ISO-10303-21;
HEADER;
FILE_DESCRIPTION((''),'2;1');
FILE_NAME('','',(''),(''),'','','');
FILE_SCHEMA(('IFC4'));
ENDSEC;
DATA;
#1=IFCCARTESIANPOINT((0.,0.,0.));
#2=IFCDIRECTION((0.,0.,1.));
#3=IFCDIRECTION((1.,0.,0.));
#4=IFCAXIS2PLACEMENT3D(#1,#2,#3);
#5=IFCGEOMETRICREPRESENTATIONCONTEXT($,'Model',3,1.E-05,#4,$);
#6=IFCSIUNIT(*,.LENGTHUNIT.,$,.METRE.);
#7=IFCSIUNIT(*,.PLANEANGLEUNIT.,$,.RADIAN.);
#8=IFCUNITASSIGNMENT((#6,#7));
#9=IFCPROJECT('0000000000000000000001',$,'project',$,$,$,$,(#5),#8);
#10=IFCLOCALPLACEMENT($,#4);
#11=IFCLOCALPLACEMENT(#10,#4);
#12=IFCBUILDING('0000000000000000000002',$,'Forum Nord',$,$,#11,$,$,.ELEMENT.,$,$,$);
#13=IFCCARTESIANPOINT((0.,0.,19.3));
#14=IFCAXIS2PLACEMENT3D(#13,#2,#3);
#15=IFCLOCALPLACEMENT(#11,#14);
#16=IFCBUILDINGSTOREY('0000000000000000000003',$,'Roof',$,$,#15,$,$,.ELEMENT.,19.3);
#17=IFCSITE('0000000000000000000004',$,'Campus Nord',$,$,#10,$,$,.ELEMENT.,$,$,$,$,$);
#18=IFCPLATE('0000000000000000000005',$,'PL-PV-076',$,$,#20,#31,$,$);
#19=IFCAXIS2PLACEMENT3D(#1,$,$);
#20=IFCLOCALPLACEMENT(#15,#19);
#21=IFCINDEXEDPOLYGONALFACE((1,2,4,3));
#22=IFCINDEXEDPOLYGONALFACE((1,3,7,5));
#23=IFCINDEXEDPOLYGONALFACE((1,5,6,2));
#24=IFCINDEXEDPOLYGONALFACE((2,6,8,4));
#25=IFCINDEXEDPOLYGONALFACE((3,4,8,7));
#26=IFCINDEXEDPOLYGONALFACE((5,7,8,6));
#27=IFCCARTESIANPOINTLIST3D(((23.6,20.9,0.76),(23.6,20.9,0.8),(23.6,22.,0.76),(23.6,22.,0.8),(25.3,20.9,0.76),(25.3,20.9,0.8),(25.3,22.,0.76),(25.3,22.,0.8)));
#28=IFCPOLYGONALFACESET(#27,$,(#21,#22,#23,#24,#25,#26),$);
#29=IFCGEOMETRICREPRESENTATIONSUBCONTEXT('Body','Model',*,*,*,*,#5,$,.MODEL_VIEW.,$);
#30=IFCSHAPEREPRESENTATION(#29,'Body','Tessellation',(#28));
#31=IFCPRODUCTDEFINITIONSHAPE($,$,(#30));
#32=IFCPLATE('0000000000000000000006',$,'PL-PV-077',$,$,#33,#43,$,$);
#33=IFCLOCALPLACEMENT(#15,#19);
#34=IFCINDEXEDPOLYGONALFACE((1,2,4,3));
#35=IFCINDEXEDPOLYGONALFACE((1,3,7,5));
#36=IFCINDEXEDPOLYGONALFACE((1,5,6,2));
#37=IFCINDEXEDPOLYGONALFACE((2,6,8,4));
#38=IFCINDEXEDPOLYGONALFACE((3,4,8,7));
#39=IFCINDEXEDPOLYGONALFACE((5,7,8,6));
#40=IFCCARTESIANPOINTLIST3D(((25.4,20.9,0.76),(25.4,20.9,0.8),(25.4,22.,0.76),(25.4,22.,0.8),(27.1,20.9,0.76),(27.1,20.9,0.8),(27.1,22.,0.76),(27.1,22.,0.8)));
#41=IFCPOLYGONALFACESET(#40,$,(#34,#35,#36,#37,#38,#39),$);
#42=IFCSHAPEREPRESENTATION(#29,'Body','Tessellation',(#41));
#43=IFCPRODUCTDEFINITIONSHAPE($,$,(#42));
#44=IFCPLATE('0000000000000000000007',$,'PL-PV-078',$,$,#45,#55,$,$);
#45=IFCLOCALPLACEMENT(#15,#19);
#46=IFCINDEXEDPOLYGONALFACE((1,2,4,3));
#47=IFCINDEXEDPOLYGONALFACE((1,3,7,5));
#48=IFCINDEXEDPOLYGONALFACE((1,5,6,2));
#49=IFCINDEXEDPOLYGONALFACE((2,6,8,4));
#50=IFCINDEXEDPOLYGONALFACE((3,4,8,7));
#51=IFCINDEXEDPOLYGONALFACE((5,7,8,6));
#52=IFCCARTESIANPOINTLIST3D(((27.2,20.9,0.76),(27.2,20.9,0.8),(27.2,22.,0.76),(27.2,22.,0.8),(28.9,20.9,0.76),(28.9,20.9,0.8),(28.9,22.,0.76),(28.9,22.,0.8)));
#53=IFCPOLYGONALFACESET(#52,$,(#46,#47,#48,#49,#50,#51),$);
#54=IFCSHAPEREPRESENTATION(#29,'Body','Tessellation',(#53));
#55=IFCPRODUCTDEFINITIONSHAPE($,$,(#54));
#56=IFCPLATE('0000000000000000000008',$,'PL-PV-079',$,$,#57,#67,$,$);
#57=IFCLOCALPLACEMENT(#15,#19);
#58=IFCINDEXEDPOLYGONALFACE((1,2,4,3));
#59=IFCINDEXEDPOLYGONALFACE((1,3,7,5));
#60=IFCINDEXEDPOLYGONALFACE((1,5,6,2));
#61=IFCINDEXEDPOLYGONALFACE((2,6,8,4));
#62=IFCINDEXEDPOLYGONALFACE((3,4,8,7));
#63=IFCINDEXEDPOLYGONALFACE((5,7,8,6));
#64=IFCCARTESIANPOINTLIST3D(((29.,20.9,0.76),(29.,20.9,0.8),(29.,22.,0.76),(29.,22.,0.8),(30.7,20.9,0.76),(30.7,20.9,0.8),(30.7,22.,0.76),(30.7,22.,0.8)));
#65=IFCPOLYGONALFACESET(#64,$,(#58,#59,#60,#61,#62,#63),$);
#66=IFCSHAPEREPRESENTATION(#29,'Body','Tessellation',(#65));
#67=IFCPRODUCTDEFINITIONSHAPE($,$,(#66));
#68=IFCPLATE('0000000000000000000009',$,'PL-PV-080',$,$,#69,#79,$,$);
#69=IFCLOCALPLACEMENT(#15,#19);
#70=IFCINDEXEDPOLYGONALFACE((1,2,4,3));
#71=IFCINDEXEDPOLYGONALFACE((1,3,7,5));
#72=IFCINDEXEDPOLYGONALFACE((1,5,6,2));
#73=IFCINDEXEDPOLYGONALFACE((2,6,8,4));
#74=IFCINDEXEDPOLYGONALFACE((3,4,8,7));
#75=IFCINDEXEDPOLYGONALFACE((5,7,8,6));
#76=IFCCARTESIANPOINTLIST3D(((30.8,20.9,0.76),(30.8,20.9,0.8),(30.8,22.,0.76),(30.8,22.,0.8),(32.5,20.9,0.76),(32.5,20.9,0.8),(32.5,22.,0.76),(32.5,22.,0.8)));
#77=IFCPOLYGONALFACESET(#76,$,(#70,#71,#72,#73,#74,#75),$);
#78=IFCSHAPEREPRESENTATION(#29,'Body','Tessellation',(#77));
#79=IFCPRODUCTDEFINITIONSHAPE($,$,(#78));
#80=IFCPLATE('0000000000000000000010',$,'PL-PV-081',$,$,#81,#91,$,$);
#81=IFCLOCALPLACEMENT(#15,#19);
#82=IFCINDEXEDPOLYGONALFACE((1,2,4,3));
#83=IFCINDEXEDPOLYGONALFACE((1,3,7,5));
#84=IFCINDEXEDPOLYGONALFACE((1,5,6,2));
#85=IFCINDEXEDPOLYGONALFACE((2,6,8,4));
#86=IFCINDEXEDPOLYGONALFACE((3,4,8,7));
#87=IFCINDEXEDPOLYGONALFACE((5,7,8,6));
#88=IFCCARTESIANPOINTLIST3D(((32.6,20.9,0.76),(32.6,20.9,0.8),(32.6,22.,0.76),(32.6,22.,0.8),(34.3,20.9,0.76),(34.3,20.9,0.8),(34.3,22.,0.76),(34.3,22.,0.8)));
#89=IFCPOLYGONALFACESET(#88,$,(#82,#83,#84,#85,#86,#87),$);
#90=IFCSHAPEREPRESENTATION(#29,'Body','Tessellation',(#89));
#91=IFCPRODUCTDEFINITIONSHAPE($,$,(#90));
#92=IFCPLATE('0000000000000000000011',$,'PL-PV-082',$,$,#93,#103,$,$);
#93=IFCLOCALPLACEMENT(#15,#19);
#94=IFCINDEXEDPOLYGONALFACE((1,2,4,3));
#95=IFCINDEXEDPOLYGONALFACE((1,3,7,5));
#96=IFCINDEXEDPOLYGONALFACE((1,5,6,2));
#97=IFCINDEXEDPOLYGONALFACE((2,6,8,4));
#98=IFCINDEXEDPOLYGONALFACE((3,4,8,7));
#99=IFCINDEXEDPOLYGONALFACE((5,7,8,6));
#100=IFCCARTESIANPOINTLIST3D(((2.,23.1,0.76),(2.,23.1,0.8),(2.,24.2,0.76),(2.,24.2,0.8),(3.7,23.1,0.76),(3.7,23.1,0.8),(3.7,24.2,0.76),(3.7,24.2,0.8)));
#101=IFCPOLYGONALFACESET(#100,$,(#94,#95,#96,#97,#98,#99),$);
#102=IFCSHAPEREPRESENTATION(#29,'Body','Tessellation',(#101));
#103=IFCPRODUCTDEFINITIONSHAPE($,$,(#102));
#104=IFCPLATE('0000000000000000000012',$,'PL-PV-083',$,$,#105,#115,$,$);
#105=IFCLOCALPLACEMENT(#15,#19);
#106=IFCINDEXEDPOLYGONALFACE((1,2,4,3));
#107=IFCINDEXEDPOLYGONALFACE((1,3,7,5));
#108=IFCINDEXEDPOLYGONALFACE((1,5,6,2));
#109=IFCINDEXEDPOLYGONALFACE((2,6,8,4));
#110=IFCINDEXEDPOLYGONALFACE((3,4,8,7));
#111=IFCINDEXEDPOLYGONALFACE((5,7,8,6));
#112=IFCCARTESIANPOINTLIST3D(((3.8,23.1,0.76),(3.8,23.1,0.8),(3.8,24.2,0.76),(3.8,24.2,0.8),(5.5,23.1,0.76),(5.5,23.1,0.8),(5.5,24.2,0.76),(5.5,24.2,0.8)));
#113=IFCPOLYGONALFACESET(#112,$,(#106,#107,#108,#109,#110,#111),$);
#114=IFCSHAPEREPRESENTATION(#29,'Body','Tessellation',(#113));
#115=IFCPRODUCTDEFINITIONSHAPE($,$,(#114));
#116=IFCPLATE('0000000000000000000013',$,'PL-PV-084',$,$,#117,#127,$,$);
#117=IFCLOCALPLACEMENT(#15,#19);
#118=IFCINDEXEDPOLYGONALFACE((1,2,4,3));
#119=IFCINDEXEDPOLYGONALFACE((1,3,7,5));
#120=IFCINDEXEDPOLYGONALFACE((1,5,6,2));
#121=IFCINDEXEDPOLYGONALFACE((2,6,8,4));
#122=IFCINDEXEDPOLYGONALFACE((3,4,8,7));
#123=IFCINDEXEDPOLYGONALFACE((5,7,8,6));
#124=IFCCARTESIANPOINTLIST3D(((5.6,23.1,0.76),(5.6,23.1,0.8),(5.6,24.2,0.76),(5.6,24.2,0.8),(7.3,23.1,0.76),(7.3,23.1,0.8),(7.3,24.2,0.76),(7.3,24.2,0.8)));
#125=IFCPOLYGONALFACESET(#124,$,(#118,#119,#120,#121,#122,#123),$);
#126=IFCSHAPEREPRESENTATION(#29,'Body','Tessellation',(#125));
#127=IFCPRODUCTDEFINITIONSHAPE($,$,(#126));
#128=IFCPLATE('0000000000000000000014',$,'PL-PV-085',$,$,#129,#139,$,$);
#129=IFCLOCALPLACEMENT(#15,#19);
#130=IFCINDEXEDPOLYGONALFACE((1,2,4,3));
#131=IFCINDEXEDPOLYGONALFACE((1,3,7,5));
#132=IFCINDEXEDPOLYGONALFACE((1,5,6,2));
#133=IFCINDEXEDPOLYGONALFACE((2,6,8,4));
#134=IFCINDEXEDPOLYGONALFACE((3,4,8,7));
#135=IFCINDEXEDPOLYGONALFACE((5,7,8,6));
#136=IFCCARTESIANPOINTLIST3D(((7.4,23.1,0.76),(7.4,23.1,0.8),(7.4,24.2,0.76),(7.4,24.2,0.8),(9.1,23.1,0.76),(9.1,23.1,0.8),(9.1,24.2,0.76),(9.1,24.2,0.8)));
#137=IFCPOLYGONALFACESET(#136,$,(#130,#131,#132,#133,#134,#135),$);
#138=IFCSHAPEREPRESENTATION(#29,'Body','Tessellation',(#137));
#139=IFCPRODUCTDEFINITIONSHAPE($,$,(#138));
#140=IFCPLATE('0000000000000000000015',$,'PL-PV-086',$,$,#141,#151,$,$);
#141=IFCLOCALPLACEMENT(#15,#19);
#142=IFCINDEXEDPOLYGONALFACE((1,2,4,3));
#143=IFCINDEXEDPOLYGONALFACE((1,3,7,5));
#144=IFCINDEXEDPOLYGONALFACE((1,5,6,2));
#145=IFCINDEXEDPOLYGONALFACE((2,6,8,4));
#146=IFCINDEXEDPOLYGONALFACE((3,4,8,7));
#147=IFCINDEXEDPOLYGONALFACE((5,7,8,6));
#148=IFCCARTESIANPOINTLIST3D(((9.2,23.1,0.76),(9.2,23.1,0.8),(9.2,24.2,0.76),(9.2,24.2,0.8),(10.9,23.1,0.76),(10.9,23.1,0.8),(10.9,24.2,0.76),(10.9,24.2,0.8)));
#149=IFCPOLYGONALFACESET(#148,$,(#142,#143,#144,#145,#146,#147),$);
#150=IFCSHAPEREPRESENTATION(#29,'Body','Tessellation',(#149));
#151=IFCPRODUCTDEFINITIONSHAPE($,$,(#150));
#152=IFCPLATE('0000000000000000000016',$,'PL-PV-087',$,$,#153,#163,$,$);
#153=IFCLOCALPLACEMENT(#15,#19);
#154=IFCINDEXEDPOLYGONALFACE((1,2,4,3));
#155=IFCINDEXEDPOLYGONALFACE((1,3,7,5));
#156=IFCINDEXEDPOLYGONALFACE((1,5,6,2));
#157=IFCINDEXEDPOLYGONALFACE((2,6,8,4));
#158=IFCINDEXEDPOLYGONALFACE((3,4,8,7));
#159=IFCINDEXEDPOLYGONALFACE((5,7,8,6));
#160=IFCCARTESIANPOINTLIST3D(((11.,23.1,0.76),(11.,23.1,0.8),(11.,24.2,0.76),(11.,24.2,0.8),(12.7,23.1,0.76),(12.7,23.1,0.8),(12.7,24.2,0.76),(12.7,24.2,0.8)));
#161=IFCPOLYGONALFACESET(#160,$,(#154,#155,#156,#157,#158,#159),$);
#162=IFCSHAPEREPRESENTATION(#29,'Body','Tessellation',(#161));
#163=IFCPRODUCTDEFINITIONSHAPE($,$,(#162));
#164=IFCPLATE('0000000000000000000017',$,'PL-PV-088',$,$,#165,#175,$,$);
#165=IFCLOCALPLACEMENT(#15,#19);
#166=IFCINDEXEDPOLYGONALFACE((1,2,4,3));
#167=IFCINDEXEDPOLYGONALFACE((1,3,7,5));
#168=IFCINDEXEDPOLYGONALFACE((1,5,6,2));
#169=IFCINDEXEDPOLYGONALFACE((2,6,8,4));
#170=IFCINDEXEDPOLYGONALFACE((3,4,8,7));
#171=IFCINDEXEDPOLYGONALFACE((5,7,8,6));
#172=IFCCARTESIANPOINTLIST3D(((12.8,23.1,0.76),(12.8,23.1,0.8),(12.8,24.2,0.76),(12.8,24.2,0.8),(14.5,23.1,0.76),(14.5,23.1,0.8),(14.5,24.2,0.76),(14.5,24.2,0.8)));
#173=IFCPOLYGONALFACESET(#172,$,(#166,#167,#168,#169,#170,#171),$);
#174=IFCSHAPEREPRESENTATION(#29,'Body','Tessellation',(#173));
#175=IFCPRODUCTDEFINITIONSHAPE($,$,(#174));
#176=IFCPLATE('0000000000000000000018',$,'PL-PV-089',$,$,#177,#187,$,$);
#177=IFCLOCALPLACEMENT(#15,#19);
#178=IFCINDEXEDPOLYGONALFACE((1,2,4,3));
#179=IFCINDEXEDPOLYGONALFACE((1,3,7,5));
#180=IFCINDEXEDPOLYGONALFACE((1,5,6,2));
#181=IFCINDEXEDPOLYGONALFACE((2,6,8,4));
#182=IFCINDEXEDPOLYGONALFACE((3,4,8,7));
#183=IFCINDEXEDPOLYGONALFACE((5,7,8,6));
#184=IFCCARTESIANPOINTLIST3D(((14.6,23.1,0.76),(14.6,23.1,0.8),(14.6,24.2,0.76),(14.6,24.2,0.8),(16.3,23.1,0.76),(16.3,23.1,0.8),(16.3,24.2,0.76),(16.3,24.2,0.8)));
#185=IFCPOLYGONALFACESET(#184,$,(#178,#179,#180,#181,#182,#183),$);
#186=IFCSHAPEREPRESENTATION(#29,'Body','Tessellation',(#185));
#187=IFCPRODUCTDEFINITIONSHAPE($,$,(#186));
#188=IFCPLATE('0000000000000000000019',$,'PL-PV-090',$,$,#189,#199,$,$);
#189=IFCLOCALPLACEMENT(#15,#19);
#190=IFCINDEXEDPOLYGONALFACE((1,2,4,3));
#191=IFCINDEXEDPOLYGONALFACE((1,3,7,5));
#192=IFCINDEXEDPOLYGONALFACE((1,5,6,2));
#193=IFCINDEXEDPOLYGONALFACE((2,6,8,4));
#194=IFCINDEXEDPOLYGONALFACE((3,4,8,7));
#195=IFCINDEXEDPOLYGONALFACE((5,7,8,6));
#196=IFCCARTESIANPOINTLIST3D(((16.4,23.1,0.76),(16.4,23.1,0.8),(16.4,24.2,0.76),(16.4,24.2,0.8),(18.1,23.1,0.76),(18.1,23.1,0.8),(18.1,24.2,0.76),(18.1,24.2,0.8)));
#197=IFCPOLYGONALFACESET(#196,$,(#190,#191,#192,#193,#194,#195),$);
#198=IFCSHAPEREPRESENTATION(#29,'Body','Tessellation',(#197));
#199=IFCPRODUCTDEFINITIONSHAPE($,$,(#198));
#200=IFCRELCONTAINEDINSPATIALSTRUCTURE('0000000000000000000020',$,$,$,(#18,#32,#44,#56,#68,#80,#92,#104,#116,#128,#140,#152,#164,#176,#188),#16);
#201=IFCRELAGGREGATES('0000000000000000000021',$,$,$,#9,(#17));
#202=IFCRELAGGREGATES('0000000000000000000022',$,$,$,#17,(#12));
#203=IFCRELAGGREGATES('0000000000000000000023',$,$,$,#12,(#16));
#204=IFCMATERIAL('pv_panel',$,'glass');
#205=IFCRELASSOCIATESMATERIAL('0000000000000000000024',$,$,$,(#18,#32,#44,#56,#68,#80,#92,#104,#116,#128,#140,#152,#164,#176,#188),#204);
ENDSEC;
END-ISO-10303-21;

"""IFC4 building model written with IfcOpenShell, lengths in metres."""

from ifc_helpers import new_model, si_unit, frame, origin_with_axes, place, context, subcontext, project, spatial, polyline, outline, extrude, material, element, save


model = new_model("IFC4")

# Units and contexts
model_context = context("Model", 3, precision=1e-05, world=origin_with_axes())
body_context = subcontext(model_context, "Body", "Model", "MODEL_VIEW")
ifc_project = project(units=[si_unit("LENGTHUNIT", "METRE"), si_unit("PLANEANGLEUNIT", "RADIAN")], contexts=[model_context])

# Site, building, storey
site_placement = place(None, origin_with_axes())
site = spatial("IfcSite", under=ifc_project, at=site_placement, Name="Campus Nord", CompositionType="ELEMENT")
building_placement = place(site_placement, origin_with_axes())
building = spatial("IfcBuilding", under=site, at=building_placement, Name="Forum Nord", CompositionType="ELEMENT")
storey_placement = place(building_placement, frame((0.0, 0.0, 19.3), z_axis=(0.0, 0.0, 1.0), x_axis=(1.0, 0.0, 0.0)))
storey = spatial("IfcBuildingStorey", under=building, at=storey_placement, Name="Roof", CompositionType="ELEMENT", Elevation=19.3)

# Plates
ifc_material_1 = material(Name="pv_panel", Category="glass")
plate_1_placement = place(storey_placement, frame((0.0, 0.0, 0.8), z_axis=(0.0, 0.0, 1.0), x_axis=(1.0, 0.0, 0.0)))
element("IfcPlate", 1, at=plate_1_placement, inside=storey, material=ifc_material_1, Name="PL-PV-076", context=body_context, shape_type="SweptSolid", body=[
    extrude(outline(polyline([(23.6, 20.9), (25.3, 20.9), (25.3, 22.0), (23.6, 22.0), (23.6, 20.9)])), frame((0.0, 0.0, -0.04), z_axis=(0.0, 0.0, 1.0), x_axis=(1.0, 0.0, 0.0)), (0.0, 0.0, 1.0), 0.04),
])
plate_2_placement = place(storey_placement, frame((0.0, 0.0, 0.8), z_axis=(0.0, 0.0, 1.0), x_axis=(1.0, 0.0, 0.0)))
element("IfcPlate", 2, at=plate_2_placement, inside=storey, material=ifc_material_1, Name="PL-PV-077", context=body_context, shape_type="SweptSolid", body=[
    extrude(outline(polyline([(25.4, 20.9), (27.1, 20.9), (27.1, 22.0), (25.4, 22.0), (25.4, 20.9)])), frame((0.0, 0.0, -0.04), z_axis=(0.0, 0.0, 1.0), x_axis=(1.0, 0.0, 0.0)), (0.0, 0.0, 1.0), 0.04),
])
plate_3_placement = place(storey_placement, frame((0.0, 0.0, 0.8), z_axis=(0.0, 0.0, 1.0), x_axis=(1.0, 0.0, 0.0)))
element("IfcPlate", 3, at=plate_3_placement, inside=storey, material=ifc_material_1, Name="PL-PV-078", context=body_context, shape_type="SweptSolid", body=[
    extrude(outline(polyline([(27.2, 20.9), (28.9, 20.9), (28.9, 22.0), (27.2, 22.0), (27.2, 20.9)])), frame((0.0, 0.0, -0.04), z_axis=(0.0, 0.0, 1.0), x_axis=(1.0, 0.0, 0.0)), (0.0, 0.0, 1.0), 0.04),
])
plate_4_placement = place(storey_placement, frame((0.0, 0.0, 0.8), z_axis=(0.0, 0.0, 1.0), x_axis=(1.0, 0.0, 0.0)))
element("IfcPlate", 4, at=plate_4_placement, inside=storey, material=ifc_material_1, Name="PL-PV-079", context=body_context, shape_type="SweptSolid", body=[
    extrude(outline(polyline([(29.0, 20.9), (30.7, 20.9), (30.7, 22.0), (29.0, 22.0), (29.0, 20.9)])), frame((0.0, 0.0, -0.04), z_axis=(0.0, 0.0, 1.0), x_axis=(1.0, 0.0, 0.0)), (0.0, 0.0, 1.0), 0.04),
])
plate_5_placement = place(storey_placement, frame((0.0, 0.0, 0.8), z_axis=(0.0, 0.0, 1.0), x_axis=(1.0, 0.0, 0.0)))
element("IfcPlate", 5, at=plate_5_placement, inside=storey, material=ifc_material_1, Name="PL-PV-080", context=body_context, shape_type="SweptSolid", body=[
    extrude(outline(polyline([(30.8, 20.9), (32.5, 20.9), (32.5, 22.0), (30.8, 22.0), (30.8, 20.9)])), frame((0.0, 0.0, -0.04), z_axis=(0.0, 0.0, 1.0), x_axis=(1.0, 0.0, 0.0)), (0.0, 0.0, 1.0), 0.04),
])
plate_6_placement = place(storey_placement, frame((0.0, 0.0, 0.8), z_axis=(0.0, 0.0, 1.0), x_axis=(1.0, 0.0, 0.0)))
element("IfcPlate", 6, at=plate_6_placement, inside=storey, material=ifc_material_1, Name="PL-PV-081", context=body_context, shape_type="SweptSolid", body=[
    extrude(outline(polyline([(32.6, 20.9), (34.3, 20.9), (34.3, 22.0), (32.6, 22.0), (32.6, 20.9)])), frame((0.0, 0.0, -0.04), z_axis=(0.0, 0.0, 1.0), x_axis=(1.0, 0.0, 0.0)), (0.0, 0.0, 1.0), 0.04),
])
plate_7_placement = place(storey_placement, frame((0.0, 0.0, 0.8), z_axis=(0.0, 0.0, 1.0), x_axis=(1.0, 0.0, 0.0)))
element("IfcPlate", 7, at=plate_7_placement, inside=storey, material=ifc_material_1, Name="PL-PV-082", context=body_context, shape_type="SweptSolid", body=[
    extrude(outline(polyline([(2.0, 23.1), (3.7, 23.1), (3.7, 24.2), (2.0, 24.2), (2.0, 23.1)])), frame((0.0, 0.0, -0.04), z_axis=(0.0, 0.0, 1.0), x_axis=(1.0, 0.0, 0.0)), (0.0, 0.0, 1.0), 0.04),
])
plate_8_placement = place(storey_placement, frame((0.0, 0.0, 0.8), z_axis=(0.0, 0.0, 1.0), x_axis=(1.0, 0.0, 0.0)))
element("IfcPlate", 8, at=plate_8_placement, inside=storey, material=ifc_material_1, Name="PL-PV-083", context=body_context, shape_type="SweptSolid", body=[
    extrude(outline(polyline([(3.8, 23.1), (5.5, 23.1), (5.5, 24.2), (3.8, 24.2), (3.8, 23.1)])), frame((0.0, 0.0, -0.04), z_axis=(0.0, 0.0, 1.0), x_axis=(1.0, 0.0, 0.0)), (0.0, 0.0, 1.0), 0.04),
])
plate_9_placement = place(storey_placement, frame((0.0, 0.0, 0.8), z_axis=(0.0, 0.0, 1.0), x_axis=(1.0, 0.0, 0.0)))
element("IfcPlate", 9, at=plate_9_placement, inside=storey, material=ifc_material_1, Name="PL-PV-084", context=body_context, shape_type="SweptSolid", body=[
    extrude(outline(polyline([(5.6, 23.1), (7.3, 23.1), (7.3, 24.2), (5.6, 24.2), (5.6, 23.1)])), frame((0.0, 0.0, -0.04), z_axis=(0.0, 0.0, 1.0), x_axis=(1.0, 0.0, 0.0)), (0.0, 0.0, 1.0), 0.04),
])
plate_10_placement = place(storey_placement, frame((0.0, 0.0, 0.8), z_axis=(0.0, 0.0, 1.0), x_axis=(1.0, 0.0, 0.0)))
element("IfcPlate", 10, at=plate_10_placement, inside=storey, material=ifc_material_1, Name="PL-PV-085", context=body_context, shape_type="SweptSolid", body=[
    extrude(outline(polyline([(7.4, 23.1), (9.1, 23.1), (9.1, 24.2), (7.4, 24.2), (7.4, 23.1)])), frame((0.0, 0.0, -0.04), z_axis=(0.0, 0.0, 1.0), x_axis=(1.0, 0.0, 0.0)), (0.0, 0.0, 1.0), 0.04),
])
plate_11_placement = place(storey_placement, frame((0.0, 0.0, 0.8), z_axis=(0.0, 0.0, 1.0), x_axis=(1.0, 0.0, 0.0)))
element("IfcPlate", 11, at=plate_11_placement, inside=storey, material=ifc_material_1, Name="PL-PV-086", context=body_context, shape_type="SweptSolid", body=[
    extrude(outline(polyline([(9.2, 23.1), (10.9, 23.1), (10.9, 24.2), (9.2, 24.2), (9.2, 23.1)])), frame((0.0, 0.0, -0.04), z_axis=(0.0, 0.0, 1.0), x_axis=(1.0, 0.0, 0.0)), (0.0, 0.0, 1.0), 0.04),
])
plate_12_placement = place(storey_placement, frame((0.0, 0.0, 0.8), z_axis=(0.0, 0.0, 1.0), x_axis=(1.0, 0.0, 0.0)))
element("IfcPlate", 12, at=plate_12_placement, inside=storey, material=ifc_material_1, Name="PL-PV-087", context=body_context, shape_type="SweptSolid", body=[
    extrude(outline(polyline([(11.0, 23.1), (12.7, 23.1), (12.7, 24.2), (11.0, 24.2), (11.0, 23.1)])), frame((0.0, 0.0, -0.04), z_axis=(0.0, 0.0, 1.0), x_axis=(1.0, 0.0, 0.0)), (0.0, 0.0, 1.0), 0.04),
])
plate_13_placement = place(storey_placement, frame((0.0, 0.0, 0.8), z_axis=(0.0, 0.0, 1.0), x_axis=(1.0, 0.0, 0.0)))
element("IfcPlate", 13, at=plate_13_placement, inside=storey, material=ifc_material_1, Name="PL-PV-088", context=body_context, shape_type="SweptSolid", body=[
    extrude(outline(polyline([(12.8, 23.1), (14.5, 23.1), (14.5, 24.2), (12.8, 24.2), (12.8, 23.1)])), frame((0.0, 0.0, -0.04), z_axis=(0.0, 0.0, 1.0), x_axis=(1.0, 0.0, 0.0)), (0.0, 0.0, 1.0), 0.04),
])
plate_14_placement = place(storey_placement, frame((0.0, 0.0, 0.8), z_axis=(0.0, 0.0, 1.0), x_axis=(1.0, 0.0, 0.0)))
element("IfcPlate", 14, at=plate_14_placement, inside=storey, material=ifc_material_1, Name="PL-PV-089", context=body_context, shape_type="SweptSolid", body=[
    extrude(outline(polyline([(14.6, 23.1), (16.3, 23.1), (16.3, 24.2), (14.6, 24.2), (14.6, 23.1)])), frame((0.0, 0.0, -0.04), z_axis=(0.0, 0.0, 1.0), x_axis=(1.0, 0.0, 0.0)), (0.0, 0.0, 1.0), 0.04),
])
plate_15_placement = place(storey_placement, frame((0.0, 0.0, 0.8), z_axis=(0.0, 0.0, 1.0), x_axis=(1.0, 0.0, 0.0)))
element("IfcPlate", 15, at=plate_15_placement, inside=storey, material=ifc_material_1, Name="PL-PV-090", context=body_context, shape_type="SweptSolid", body=[
    extrude(outline(polyline([(16.4, 23.1), (18.1, 23.1), (18.1, 24.2), (16.4, 24.2), (16.4, 23.1)])), frame((0.0, 0.0, -0.04), z_axis=(0.0, 0.0, 1.0), x_axis=(1.0, 0.0, 0.0)), (0.0, 0.0, 1.0), 0.04),
])

save(model, "model.ifc")
